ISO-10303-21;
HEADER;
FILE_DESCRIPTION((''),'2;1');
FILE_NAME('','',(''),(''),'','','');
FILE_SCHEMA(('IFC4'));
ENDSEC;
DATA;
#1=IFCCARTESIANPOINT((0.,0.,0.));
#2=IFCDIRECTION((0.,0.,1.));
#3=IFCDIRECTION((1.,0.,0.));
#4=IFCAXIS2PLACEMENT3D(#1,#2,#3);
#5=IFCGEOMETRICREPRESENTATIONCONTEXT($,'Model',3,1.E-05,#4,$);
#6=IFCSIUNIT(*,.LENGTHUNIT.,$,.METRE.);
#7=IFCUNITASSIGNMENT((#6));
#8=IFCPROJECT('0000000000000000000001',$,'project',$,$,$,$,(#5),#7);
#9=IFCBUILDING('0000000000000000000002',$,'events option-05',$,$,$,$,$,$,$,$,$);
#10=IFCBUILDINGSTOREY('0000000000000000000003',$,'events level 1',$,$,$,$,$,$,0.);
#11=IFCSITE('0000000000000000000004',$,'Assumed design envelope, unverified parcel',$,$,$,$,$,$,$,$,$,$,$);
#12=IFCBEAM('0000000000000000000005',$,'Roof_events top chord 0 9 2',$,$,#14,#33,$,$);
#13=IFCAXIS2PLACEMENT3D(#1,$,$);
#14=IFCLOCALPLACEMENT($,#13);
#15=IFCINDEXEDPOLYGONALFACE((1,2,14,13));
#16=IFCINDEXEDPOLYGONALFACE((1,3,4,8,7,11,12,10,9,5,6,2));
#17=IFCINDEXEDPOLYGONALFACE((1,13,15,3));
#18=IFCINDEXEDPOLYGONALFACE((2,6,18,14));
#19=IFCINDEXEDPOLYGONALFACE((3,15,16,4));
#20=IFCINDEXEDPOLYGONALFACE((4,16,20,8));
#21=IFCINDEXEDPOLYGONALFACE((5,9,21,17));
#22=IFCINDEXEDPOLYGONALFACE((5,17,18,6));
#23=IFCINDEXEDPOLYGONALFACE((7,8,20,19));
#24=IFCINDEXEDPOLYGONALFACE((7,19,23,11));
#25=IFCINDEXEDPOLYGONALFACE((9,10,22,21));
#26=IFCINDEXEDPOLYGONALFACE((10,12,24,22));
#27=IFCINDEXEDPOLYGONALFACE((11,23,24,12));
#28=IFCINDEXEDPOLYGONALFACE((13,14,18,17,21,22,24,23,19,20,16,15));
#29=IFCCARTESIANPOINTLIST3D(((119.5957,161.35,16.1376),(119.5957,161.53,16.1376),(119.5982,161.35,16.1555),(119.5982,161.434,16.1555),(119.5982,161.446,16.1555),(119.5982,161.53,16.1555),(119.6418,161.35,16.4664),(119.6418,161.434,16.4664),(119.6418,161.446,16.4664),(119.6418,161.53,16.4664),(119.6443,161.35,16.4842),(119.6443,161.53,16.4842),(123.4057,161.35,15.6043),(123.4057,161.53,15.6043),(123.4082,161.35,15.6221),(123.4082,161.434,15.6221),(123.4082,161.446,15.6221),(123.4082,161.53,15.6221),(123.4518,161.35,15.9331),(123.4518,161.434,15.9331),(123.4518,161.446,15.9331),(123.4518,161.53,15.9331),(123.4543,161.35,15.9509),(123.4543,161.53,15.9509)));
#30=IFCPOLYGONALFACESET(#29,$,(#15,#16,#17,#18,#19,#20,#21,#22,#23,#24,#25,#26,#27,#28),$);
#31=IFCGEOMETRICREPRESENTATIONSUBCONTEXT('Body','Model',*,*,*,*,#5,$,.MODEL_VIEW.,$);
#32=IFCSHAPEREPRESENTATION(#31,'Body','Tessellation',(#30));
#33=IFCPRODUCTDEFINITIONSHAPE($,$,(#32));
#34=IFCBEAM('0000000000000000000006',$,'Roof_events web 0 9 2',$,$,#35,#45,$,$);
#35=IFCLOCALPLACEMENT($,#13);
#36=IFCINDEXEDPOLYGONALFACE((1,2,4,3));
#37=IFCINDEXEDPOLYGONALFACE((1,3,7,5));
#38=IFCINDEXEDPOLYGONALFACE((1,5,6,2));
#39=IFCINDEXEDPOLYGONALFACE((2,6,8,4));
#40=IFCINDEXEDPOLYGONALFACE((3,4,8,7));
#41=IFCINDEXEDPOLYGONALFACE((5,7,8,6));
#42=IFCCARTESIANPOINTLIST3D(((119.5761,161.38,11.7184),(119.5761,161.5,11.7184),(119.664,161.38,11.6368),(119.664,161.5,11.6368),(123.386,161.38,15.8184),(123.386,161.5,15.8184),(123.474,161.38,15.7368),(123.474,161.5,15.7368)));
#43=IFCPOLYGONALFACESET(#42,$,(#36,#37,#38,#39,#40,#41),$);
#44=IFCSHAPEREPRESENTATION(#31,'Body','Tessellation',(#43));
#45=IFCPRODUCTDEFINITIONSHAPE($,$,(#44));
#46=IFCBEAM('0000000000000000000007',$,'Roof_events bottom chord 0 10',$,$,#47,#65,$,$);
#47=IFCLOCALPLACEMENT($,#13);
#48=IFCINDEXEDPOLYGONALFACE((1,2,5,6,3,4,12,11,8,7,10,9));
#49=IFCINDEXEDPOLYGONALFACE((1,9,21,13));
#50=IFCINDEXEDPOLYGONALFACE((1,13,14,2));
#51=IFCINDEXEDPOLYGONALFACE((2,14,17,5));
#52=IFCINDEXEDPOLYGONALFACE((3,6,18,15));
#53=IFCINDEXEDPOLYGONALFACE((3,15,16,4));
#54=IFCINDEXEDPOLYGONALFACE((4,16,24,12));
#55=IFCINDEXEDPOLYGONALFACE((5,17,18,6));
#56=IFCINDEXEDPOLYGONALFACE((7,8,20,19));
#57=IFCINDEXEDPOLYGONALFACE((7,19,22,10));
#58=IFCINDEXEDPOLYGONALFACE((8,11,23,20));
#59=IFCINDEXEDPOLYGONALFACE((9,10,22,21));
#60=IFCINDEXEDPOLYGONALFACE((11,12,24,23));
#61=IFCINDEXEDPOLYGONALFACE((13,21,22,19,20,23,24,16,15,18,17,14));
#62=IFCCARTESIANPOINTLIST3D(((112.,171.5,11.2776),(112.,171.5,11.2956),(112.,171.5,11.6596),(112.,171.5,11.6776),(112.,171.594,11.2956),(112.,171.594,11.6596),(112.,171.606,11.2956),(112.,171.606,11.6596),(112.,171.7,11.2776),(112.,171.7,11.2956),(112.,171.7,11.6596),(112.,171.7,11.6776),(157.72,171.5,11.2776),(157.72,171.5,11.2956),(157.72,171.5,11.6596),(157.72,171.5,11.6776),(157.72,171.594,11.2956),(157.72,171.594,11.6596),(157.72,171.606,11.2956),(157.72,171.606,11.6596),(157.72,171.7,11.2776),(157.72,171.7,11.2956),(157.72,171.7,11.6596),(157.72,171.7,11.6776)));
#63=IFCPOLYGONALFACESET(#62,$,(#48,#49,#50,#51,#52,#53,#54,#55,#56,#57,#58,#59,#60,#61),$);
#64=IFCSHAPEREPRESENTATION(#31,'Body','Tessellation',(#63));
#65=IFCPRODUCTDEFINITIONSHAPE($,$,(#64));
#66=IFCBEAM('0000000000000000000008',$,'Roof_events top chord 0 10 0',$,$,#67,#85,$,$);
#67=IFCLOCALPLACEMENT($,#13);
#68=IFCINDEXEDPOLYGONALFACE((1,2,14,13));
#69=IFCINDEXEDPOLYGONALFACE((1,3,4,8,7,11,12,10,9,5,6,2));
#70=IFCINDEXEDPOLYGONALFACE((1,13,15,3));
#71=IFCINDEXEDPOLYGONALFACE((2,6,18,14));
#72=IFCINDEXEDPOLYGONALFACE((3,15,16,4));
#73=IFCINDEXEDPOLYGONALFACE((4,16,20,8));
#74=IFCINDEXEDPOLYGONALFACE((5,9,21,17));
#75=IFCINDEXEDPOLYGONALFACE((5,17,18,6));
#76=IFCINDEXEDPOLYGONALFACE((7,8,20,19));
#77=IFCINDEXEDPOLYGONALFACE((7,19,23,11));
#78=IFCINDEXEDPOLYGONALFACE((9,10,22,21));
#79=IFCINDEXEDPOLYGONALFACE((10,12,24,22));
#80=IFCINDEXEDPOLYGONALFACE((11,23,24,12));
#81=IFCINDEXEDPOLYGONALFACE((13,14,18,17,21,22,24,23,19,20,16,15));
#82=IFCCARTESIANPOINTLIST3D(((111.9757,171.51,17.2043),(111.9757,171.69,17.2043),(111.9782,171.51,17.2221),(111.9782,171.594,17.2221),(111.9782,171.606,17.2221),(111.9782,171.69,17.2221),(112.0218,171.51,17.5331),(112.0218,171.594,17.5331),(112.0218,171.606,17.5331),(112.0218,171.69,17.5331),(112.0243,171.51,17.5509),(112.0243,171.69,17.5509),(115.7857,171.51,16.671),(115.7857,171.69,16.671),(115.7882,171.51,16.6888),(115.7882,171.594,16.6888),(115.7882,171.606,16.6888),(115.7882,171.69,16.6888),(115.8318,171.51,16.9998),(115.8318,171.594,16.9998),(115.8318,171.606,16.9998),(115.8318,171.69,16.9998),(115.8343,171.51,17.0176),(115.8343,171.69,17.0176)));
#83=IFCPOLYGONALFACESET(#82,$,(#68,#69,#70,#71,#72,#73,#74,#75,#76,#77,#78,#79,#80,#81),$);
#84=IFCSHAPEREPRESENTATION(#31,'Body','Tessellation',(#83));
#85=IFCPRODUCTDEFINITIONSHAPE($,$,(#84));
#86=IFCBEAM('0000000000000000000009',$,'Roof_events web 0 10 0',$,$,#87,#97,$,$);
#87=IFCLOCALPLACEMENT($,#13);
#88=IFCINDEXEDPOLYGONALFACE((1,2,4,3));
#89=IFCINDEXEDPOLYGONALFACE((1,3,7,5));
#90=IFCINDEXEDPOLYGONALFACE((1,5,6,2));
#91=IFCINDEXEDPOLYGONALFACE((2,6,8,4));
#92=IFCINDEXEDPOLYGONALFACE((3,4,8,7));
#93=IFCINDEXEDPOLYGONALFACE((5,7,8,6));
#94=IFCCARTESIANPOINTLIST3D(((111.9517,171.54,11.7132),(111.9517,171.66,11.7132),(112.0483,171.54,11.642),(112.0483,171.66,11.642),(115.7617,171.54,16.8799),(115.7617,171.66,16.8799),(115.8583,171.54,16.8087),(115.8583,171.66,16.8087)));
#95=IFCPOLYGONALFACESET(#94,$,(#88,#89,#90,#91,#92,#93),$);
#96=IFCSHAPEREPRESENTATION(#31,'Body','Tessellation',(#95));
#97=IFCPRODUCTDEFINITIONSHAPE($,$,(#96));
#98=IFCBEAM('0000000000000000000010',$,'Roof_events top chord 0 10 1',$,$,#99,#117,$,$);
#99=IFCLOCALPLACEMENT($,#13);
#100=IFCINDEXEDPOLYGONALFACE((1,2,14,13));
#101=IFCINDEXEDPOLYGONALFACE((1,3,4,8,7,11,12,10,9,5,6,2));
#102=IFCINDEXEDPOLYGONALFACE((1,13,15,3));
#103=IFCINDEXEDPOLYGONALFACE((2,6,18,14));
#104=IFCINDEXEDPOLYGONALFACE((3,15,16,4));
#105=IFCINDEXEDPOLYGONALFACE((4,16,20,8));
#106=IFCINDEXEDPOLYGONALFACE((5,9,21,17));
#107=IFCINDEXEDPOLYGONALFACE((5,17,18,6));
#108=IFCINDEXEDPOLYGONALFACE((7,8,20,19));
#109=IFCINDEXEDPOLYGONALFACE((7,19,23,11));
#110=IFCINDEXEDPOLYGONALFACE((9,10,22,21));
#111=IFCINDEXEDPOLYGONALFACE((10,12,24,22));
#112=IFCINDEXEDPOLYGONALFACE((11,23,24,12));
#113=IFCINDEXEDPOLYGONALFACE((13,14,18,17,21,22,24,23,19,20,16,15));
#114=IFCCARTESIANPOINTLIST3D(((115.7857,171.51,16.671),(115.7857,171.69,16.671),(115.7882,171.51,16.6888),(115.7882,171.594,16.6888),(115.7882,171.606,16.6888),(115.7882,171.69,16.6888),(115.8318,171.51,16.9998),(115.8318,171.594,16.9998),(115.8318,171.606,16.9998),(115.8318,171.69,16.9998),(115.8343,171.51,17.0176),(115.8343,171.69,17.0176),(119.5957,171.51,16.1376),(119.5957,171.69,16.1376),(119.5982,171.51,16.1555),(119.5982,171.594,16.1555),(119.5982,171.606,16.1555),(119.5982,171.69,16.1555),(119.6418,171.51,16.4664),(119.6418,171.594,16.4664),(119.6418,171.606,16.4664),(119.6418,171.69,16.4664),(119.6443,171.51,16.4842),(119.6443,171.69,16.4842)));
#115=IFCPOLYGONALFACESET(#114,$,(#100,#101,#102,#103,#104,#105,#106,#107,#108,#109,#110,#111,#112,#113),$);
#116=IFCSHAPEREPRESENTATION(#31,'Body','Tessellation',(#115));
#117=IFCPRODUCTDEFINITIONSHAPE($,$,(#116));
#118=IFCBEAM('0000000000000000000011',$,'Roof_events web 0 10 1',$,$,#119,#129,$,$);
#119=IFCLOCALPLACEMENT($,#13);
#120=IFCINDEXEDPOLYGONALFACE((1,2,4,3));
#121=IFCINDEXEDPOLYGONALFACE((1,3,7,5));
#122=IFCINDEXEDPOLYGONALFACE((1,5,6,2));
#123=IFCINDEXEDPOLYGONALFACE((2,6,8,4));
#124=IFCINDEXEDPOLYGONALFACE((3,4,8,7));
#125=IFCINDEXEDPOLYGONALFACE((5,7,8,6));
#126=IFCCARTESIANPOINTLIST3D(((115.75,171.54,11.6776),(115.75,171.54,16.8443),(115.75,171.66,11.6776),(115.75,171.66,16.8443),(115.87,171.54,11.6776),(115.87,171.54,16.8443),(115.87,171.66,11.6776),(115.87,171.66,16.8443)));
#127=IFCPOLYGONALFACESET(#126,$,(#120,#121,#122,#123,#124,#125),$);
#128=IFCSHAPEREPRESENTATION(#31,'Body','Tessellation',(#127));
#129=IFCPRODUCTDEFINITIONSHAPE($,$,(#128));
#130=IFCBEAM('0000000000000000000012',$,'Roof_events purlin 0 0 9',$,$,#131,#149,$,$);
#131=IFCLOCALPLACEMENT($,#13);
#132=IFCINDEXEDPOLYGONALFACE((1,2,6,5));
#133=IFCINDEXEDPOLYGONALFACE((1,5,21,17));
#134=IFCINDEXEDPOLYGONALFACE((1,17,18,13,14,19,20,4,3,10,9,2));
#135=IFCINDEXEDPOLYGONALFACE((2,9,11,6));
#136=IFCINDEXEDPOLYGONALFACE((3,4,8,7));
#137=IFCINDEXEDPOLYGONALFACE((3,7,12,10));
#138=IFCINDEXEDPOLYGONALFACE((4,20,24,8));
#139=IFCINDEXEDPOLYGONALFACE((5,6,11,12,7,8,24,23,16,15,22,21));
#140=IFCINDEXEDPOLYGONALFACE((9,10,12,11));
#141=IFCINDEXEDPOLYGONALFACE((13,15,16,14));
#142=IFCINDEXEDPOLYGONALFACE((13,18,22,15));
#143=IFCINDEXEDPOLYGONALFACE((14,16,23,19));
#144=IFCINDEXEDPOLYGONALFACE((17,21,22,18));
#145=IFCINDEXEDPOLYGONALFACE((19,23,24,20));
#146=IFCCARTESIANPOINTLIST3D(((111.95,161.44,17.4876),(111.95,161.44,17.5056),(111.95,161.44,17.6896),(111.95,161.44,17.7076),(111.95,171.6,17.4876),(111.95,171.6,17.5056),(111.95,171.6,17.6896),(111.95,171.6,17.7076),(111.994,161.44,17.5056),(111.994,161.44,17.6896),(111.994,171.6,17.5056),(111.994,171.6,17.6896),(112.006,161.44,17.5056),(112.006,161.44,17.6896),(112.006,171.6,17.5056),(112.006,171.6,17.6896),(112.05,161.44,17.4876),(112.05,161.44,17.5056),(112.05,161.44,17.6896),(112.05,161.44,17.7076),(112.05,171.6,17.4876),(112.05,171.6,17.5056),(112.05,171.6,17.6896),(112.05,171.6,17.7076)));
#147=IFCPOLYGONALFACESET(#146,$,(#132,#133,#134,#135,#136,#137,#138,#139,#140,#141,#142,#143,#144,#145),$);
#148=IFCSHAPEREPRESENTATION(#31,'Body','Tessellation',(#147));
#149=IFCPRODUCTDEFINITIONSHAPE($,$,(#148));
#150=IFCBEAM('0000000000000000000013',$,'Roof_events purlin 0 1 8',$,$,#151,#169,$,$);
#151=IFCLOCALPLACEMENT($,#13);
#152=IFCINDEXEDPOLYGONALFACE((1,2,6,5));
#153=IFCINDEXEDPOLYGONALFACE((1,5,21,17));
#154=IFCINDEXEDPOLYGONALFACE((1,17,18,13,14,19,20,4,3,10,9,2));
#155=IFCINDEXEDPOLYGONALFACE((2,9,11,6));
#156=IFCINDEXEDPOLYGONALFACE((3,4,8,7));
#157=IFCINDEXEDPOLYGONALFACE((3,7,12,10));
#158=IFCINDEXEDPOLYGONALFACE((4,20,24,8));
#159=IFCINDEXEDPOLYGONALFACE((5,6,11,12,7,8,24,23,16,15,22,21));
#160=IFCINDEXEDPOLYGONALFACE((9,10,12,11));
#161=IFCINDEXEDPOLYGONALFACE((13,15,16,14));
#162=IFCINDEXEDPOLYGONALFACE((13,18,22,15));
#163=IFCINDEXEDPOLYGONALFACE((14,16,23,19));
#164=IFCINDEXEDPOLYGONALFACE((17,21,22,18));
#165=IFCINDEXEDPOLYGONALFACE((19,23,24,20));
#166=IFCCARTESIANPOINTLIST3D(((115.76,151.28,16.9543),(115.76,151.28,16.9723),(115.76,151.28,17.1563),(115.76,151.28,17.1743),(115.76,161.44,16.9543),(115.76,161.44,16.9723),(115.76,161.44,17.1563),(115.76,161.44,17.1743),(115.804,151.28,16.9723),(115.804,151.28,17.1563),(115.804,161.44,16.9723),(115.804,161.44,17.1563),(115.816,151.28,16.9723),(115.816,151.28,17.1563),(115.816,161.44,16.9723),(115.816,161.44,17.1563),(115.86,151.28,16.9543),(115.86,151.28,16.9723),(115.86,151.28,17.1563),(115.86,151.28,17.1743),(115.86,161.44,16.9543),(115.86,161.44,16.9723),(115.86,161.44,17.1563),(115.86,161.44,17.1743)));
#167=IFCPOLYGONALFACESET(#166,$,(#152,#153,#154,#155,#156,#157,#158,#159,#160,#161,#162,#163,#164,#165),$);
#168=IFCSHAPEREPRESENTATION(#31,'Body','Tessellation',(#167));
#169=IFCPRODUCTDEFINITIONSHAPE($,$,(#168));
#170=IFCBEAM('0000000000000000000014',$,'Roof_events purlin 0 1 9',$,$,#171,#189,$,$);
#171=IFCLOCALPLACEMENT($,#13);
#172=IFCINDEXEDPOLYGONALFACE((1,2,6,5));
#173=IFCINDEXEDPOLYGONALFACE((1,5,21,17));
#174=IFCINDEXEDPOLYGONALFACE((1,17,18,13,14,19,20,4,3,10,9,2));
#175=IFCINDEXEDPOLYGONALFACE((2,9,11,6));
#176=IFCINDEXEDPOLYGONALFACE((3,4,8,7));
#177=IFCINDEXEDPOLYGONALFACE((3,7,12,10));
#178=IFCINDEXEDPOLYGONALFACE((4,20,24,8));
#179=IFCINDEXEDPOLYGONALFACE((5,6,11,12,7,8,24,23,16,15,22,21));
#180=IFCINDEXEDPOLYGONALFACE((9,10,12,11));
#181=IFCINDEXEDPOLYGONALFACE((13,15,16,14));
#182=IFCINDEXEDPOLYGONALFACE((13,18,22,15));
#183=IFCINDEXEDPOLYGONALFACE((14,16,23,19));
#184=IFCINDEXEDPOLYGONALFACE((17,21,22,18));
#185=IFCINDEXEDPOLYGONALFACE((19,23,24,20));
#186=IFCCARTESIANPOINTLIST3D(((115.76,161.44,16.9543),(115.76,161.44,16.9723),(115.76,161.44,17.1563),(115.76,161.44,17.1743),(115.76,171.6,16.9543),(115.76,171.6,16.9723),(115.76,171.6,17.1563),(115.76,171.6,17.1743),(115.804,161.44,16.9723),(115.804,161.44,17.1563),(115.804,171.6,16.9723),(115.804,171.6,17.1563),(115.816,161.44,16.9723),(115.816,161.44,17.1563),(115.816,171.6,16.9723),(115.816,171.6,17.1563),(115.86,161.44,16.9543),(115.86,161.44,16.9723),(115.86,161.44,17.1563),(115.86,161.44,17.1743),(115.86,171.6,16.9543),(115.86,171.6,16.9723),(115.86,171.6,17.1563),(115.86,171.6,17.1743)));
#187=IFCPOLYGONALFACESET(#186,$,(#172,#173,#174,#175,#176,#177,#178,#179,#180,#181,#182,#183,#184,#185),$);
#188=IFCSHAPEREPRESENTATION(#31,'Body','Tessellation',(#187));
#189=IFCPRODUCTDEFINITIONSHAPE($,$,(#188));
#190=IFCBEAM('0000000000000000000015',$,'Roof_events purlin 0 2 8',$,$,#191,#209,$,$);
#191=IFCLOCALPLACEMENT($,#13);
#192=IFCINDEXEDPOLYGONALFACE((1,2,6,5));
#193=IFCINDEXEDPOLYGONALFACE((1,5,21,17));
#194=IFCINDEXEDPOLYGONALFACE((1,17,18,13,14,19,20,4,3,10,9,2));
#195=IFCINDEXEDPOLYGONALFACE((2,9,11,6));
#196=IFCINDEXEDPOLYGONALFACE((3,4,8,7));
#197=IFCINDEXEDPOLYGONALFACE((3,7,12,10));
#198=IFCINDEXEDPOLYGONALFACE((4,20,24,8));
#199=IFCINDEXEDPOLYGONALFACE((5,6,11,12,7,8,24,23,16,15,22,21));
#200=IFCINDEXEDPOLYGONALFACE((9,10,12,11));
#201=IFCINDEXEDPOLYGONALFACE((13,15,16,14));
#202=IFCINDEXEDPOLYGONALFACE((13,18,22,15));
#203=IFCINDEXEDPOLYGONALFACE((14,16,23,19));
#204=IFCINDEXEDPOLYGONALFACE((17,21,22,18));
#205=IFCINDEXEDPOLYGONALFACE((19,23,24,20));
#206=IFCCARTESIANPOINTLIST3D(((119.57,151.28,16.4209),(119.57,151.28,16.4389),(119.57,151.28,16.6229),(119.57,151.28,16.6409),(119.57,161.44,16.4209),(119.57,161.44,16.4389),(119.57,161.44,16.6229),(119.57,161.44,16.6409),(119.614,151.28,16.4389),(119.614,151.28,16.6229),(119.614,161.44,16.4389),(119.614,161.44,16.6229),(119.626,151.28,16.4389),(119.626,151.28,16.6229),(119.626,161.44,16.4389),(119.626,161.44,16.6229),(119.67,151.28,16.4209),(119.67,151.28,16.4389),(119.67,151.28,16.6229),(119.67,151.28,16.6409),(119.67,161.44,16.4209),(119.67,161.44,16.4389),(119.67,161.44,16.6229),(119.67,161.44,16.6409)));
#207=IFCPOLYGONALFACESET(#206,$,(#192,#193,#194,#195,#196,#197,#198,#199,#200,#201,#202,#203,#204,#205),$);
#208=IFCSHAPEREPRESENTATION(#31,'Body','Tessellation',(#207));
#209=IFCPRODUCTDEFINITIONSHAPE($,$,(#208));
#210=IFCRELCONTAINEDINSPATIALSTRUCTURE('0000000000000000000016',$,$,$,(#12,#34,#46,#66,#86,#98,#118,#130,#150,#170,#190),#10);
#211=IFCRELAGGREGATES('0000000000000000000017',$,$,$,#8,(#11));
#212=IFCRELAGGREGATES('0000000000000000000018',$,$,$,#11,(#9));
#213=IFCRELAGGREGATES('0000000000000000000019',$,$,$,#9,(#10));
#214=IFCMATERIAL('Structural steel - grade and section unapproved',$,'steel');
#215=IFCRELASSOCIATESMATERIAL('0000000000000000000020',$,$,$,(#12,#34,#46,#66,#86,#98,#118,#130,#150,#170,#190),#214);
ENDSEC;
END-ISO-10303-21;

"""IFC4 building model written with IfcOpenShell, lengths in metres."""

from ifc_helpers import new_model, si_unit, frame, origin_with_axes, place, context, subcontext, project, spatial, rectangle, i_section, extrude, material, element, save


model = new_model("IFC4")

# Units and contexts
model_context = context("Model", 3, precision=1e-05, world=origin_with_axes())
body_context = subcontext(model_context, "Body", "Model", "MODEL_VIEW")
ifc_project = project(units=[si_unit("LENGTHUNIT", "METRE")], contexts=[model_context])

# Site, building, storey
site = spatial("IfcSite", under=ifc_project, Name="Assumed design envelope, unverified parcel")
building = spatial("IfcBuilding", under=site, Name="events option-05")
storey = spatial("IfcBuildingStorey", under=building, Name="events level 1", Elevation=0.0)

# Shared definitions
ifc_material_1 = material(Name="Structural steel - grade and section unapproved", Category="steel")

# Beams
beam_1_placement = place(None, frame((119.62, 161.44, 16.3109), z_axis=(0.990344, 0.0, -0.138631), x_axis=(0.0, 1.0, 0.0)))
element("IfcBeam", 1, at=beam_1_placement, inside=storey, material=ifc_material_1, Name="Roof_events top chord 0 9 2", context=body_context, shape_type="SweptSolid", body=[
    extrude(i_section(OverallWidth=0.18, OverallDepth=0.35, WebThickness=0.012, FlangeThickness=0.018, FilletRadius=0.0), origin_with_axes(), (0.0, 0.0, 1.0), 3.8471),
])
beam_2_placement = place(None, frame((119.62, 161.44, 11.6776), z_axis=(0.680725, 0.0, 0.732539), x_axis=(0.0, 1.0, 0.0)))
element("IfcBeam", 2, at=beam_2_placement, inside=storey, material=ifc_material_1, Name="Roof_events web 0 9 2", context=body_context, shape_type="SweptSolid", body=[
    extrude(rectangle(XDim=0.12, YDim=0.12), origin_with_axes(), (0.0, 0.0, 1.0), 5.597),
])
beam_3_placement = place(None, frame((112.0, 171.6, 11.4776), z_axis=(1.0, 0.0, 0.0), x_axis=(0.0, 1.0, 0.0)))
element("IfcBeam", 3, at=beam_3_placement, inside=storey, material=ifc_material_1, Name="Roof_events bottom chord 0 10", context=body_context, shape_type="SweptSolid", body=[
    extrude(i_section(OverallWidth=0.2, OverallDepth=0.4, WebThickness=0.012, FlangeThickness=0.018, FilletRadius=0.0), origin_with_axes(), (0.0, 0.0, 1.0), 45.72),
])
beam_4_placement = place(None, frame((112.0, 171.6, 17.3776), z_axis=(0.990344, 0.0, -0.138631), x_axis=(0.0, 1.0, 0.0)))
element("IfcBeam", 4, at=beam_4_placement, inside=storey, material=ifc_material_1, Name="Roof_events top chord 0 10 0", context=body_context, shape_type="SweptSolid", body=[
    extrude(i_section(OverallWidth=0.18, OverallDepth=0.35, WebThickness=0.012, FlangeThickness=0.018, FilletRadius=0.0), origin_with_axes(), (0.0, 0.0, 1.0), 3.8471),
])
beam_5_placement = place(None, frame((112.0, 171.6, 11.6776), z_axis=(0.5935, 0.0, 0.804834), x_axis=(0.0, 1.0, 0.0)))
element("IfcBeam", 5, at=beam_5_placement, inside=storey, material=ifc_material_1, Name="Roof_events web 0 10 0", context=body_context, shape_type="SweptSolid", body=[
    extrude(rectangle(XDim=0.12, YDim=0.12), origin_with_axes(), (0.0, 0.0, 1.0), 6.4195),
])
beam_6_placement = place(None, frame((115.81, 171.6, 16.8443), z_axis=(0.990344, 0.0, -0.138631), x_axis=(0.0, 1.0, 0.0)))
element("IfcBeam", 6, at=beam_6_placement, inside=storey, material=ifc_material_1, Name="Roof_events top chord 0 10 1", context=body_context, shape_type="SweptSolid", body=[
    extrude(i_section(OverallWidth=0.18, OverallDepth=0.35, WebThickness=0.012, FlangeThickness=0.018, FilletRadius=0.0), origin_with_axes(), (0.0, 0.0, 1.0), 3.8472),
])
beam_7_placement = place(None, frame((115.81, 171.6, 11.6776), z_axis=(0.0, 0.0, 1.0), x_axis=(-1.0, 0.0, 0.0)))
element("IfcBeam", 7, at=beam_7_placement, inside=storey, material=ifc_material_1, Name="Roof_events web 0 10 1", context=body_context, shape_type="SweptSolid", body=[
    extrude(rectangle(XDim=0.12, YDim=0.12), origin_with_axes(), (0.0, 0.0, 1.0), 5.1667),
])
for number, where, z_axis, x_axis, name in (
    (8, (112.0, 161.44, 17.5976), (0.0, 1.0, 0.0), (-1.0, 0.0, 0.0), "Roof_events purlin 0 0 9"),
    (9, (115.81, 151.28, 17.0643), (0.0, 1.0, 0.0), (-1.0, 0.0, 0.0), "Roof_events purlin 0 1 8"),
    (10, (115.81, 161.44, 17.0643), (0.0, 1.0, 0.0), (-1.0, 0.0, 0.0), "Roof_events purlin 0 1 9"),
    (11, (119.62, 151.28, 16.5309), (0.0, 1.0, 0.0), (-1.0, 0.0, 0.0), "Roof_events purlin 0 2 8"),
):
    element("IfcBeam", number, at=place(None, frame(where, z_axis=z_axis, x_axis=x_axis)), inside=storey, material=ifc_material_1, Name=name, context=body_context, shape_type="SweptSolid", body=[
        extrude(i_section(OverallWidth=0.1, OverallDepth=0.22, WebThickness=0.012, FlangeThickness=0.018, FilletRadius=0.0), origin_with_axes(), (0.0, 0.0, 1.0), 10.16),
    ])

save(model, "model.ifc")
